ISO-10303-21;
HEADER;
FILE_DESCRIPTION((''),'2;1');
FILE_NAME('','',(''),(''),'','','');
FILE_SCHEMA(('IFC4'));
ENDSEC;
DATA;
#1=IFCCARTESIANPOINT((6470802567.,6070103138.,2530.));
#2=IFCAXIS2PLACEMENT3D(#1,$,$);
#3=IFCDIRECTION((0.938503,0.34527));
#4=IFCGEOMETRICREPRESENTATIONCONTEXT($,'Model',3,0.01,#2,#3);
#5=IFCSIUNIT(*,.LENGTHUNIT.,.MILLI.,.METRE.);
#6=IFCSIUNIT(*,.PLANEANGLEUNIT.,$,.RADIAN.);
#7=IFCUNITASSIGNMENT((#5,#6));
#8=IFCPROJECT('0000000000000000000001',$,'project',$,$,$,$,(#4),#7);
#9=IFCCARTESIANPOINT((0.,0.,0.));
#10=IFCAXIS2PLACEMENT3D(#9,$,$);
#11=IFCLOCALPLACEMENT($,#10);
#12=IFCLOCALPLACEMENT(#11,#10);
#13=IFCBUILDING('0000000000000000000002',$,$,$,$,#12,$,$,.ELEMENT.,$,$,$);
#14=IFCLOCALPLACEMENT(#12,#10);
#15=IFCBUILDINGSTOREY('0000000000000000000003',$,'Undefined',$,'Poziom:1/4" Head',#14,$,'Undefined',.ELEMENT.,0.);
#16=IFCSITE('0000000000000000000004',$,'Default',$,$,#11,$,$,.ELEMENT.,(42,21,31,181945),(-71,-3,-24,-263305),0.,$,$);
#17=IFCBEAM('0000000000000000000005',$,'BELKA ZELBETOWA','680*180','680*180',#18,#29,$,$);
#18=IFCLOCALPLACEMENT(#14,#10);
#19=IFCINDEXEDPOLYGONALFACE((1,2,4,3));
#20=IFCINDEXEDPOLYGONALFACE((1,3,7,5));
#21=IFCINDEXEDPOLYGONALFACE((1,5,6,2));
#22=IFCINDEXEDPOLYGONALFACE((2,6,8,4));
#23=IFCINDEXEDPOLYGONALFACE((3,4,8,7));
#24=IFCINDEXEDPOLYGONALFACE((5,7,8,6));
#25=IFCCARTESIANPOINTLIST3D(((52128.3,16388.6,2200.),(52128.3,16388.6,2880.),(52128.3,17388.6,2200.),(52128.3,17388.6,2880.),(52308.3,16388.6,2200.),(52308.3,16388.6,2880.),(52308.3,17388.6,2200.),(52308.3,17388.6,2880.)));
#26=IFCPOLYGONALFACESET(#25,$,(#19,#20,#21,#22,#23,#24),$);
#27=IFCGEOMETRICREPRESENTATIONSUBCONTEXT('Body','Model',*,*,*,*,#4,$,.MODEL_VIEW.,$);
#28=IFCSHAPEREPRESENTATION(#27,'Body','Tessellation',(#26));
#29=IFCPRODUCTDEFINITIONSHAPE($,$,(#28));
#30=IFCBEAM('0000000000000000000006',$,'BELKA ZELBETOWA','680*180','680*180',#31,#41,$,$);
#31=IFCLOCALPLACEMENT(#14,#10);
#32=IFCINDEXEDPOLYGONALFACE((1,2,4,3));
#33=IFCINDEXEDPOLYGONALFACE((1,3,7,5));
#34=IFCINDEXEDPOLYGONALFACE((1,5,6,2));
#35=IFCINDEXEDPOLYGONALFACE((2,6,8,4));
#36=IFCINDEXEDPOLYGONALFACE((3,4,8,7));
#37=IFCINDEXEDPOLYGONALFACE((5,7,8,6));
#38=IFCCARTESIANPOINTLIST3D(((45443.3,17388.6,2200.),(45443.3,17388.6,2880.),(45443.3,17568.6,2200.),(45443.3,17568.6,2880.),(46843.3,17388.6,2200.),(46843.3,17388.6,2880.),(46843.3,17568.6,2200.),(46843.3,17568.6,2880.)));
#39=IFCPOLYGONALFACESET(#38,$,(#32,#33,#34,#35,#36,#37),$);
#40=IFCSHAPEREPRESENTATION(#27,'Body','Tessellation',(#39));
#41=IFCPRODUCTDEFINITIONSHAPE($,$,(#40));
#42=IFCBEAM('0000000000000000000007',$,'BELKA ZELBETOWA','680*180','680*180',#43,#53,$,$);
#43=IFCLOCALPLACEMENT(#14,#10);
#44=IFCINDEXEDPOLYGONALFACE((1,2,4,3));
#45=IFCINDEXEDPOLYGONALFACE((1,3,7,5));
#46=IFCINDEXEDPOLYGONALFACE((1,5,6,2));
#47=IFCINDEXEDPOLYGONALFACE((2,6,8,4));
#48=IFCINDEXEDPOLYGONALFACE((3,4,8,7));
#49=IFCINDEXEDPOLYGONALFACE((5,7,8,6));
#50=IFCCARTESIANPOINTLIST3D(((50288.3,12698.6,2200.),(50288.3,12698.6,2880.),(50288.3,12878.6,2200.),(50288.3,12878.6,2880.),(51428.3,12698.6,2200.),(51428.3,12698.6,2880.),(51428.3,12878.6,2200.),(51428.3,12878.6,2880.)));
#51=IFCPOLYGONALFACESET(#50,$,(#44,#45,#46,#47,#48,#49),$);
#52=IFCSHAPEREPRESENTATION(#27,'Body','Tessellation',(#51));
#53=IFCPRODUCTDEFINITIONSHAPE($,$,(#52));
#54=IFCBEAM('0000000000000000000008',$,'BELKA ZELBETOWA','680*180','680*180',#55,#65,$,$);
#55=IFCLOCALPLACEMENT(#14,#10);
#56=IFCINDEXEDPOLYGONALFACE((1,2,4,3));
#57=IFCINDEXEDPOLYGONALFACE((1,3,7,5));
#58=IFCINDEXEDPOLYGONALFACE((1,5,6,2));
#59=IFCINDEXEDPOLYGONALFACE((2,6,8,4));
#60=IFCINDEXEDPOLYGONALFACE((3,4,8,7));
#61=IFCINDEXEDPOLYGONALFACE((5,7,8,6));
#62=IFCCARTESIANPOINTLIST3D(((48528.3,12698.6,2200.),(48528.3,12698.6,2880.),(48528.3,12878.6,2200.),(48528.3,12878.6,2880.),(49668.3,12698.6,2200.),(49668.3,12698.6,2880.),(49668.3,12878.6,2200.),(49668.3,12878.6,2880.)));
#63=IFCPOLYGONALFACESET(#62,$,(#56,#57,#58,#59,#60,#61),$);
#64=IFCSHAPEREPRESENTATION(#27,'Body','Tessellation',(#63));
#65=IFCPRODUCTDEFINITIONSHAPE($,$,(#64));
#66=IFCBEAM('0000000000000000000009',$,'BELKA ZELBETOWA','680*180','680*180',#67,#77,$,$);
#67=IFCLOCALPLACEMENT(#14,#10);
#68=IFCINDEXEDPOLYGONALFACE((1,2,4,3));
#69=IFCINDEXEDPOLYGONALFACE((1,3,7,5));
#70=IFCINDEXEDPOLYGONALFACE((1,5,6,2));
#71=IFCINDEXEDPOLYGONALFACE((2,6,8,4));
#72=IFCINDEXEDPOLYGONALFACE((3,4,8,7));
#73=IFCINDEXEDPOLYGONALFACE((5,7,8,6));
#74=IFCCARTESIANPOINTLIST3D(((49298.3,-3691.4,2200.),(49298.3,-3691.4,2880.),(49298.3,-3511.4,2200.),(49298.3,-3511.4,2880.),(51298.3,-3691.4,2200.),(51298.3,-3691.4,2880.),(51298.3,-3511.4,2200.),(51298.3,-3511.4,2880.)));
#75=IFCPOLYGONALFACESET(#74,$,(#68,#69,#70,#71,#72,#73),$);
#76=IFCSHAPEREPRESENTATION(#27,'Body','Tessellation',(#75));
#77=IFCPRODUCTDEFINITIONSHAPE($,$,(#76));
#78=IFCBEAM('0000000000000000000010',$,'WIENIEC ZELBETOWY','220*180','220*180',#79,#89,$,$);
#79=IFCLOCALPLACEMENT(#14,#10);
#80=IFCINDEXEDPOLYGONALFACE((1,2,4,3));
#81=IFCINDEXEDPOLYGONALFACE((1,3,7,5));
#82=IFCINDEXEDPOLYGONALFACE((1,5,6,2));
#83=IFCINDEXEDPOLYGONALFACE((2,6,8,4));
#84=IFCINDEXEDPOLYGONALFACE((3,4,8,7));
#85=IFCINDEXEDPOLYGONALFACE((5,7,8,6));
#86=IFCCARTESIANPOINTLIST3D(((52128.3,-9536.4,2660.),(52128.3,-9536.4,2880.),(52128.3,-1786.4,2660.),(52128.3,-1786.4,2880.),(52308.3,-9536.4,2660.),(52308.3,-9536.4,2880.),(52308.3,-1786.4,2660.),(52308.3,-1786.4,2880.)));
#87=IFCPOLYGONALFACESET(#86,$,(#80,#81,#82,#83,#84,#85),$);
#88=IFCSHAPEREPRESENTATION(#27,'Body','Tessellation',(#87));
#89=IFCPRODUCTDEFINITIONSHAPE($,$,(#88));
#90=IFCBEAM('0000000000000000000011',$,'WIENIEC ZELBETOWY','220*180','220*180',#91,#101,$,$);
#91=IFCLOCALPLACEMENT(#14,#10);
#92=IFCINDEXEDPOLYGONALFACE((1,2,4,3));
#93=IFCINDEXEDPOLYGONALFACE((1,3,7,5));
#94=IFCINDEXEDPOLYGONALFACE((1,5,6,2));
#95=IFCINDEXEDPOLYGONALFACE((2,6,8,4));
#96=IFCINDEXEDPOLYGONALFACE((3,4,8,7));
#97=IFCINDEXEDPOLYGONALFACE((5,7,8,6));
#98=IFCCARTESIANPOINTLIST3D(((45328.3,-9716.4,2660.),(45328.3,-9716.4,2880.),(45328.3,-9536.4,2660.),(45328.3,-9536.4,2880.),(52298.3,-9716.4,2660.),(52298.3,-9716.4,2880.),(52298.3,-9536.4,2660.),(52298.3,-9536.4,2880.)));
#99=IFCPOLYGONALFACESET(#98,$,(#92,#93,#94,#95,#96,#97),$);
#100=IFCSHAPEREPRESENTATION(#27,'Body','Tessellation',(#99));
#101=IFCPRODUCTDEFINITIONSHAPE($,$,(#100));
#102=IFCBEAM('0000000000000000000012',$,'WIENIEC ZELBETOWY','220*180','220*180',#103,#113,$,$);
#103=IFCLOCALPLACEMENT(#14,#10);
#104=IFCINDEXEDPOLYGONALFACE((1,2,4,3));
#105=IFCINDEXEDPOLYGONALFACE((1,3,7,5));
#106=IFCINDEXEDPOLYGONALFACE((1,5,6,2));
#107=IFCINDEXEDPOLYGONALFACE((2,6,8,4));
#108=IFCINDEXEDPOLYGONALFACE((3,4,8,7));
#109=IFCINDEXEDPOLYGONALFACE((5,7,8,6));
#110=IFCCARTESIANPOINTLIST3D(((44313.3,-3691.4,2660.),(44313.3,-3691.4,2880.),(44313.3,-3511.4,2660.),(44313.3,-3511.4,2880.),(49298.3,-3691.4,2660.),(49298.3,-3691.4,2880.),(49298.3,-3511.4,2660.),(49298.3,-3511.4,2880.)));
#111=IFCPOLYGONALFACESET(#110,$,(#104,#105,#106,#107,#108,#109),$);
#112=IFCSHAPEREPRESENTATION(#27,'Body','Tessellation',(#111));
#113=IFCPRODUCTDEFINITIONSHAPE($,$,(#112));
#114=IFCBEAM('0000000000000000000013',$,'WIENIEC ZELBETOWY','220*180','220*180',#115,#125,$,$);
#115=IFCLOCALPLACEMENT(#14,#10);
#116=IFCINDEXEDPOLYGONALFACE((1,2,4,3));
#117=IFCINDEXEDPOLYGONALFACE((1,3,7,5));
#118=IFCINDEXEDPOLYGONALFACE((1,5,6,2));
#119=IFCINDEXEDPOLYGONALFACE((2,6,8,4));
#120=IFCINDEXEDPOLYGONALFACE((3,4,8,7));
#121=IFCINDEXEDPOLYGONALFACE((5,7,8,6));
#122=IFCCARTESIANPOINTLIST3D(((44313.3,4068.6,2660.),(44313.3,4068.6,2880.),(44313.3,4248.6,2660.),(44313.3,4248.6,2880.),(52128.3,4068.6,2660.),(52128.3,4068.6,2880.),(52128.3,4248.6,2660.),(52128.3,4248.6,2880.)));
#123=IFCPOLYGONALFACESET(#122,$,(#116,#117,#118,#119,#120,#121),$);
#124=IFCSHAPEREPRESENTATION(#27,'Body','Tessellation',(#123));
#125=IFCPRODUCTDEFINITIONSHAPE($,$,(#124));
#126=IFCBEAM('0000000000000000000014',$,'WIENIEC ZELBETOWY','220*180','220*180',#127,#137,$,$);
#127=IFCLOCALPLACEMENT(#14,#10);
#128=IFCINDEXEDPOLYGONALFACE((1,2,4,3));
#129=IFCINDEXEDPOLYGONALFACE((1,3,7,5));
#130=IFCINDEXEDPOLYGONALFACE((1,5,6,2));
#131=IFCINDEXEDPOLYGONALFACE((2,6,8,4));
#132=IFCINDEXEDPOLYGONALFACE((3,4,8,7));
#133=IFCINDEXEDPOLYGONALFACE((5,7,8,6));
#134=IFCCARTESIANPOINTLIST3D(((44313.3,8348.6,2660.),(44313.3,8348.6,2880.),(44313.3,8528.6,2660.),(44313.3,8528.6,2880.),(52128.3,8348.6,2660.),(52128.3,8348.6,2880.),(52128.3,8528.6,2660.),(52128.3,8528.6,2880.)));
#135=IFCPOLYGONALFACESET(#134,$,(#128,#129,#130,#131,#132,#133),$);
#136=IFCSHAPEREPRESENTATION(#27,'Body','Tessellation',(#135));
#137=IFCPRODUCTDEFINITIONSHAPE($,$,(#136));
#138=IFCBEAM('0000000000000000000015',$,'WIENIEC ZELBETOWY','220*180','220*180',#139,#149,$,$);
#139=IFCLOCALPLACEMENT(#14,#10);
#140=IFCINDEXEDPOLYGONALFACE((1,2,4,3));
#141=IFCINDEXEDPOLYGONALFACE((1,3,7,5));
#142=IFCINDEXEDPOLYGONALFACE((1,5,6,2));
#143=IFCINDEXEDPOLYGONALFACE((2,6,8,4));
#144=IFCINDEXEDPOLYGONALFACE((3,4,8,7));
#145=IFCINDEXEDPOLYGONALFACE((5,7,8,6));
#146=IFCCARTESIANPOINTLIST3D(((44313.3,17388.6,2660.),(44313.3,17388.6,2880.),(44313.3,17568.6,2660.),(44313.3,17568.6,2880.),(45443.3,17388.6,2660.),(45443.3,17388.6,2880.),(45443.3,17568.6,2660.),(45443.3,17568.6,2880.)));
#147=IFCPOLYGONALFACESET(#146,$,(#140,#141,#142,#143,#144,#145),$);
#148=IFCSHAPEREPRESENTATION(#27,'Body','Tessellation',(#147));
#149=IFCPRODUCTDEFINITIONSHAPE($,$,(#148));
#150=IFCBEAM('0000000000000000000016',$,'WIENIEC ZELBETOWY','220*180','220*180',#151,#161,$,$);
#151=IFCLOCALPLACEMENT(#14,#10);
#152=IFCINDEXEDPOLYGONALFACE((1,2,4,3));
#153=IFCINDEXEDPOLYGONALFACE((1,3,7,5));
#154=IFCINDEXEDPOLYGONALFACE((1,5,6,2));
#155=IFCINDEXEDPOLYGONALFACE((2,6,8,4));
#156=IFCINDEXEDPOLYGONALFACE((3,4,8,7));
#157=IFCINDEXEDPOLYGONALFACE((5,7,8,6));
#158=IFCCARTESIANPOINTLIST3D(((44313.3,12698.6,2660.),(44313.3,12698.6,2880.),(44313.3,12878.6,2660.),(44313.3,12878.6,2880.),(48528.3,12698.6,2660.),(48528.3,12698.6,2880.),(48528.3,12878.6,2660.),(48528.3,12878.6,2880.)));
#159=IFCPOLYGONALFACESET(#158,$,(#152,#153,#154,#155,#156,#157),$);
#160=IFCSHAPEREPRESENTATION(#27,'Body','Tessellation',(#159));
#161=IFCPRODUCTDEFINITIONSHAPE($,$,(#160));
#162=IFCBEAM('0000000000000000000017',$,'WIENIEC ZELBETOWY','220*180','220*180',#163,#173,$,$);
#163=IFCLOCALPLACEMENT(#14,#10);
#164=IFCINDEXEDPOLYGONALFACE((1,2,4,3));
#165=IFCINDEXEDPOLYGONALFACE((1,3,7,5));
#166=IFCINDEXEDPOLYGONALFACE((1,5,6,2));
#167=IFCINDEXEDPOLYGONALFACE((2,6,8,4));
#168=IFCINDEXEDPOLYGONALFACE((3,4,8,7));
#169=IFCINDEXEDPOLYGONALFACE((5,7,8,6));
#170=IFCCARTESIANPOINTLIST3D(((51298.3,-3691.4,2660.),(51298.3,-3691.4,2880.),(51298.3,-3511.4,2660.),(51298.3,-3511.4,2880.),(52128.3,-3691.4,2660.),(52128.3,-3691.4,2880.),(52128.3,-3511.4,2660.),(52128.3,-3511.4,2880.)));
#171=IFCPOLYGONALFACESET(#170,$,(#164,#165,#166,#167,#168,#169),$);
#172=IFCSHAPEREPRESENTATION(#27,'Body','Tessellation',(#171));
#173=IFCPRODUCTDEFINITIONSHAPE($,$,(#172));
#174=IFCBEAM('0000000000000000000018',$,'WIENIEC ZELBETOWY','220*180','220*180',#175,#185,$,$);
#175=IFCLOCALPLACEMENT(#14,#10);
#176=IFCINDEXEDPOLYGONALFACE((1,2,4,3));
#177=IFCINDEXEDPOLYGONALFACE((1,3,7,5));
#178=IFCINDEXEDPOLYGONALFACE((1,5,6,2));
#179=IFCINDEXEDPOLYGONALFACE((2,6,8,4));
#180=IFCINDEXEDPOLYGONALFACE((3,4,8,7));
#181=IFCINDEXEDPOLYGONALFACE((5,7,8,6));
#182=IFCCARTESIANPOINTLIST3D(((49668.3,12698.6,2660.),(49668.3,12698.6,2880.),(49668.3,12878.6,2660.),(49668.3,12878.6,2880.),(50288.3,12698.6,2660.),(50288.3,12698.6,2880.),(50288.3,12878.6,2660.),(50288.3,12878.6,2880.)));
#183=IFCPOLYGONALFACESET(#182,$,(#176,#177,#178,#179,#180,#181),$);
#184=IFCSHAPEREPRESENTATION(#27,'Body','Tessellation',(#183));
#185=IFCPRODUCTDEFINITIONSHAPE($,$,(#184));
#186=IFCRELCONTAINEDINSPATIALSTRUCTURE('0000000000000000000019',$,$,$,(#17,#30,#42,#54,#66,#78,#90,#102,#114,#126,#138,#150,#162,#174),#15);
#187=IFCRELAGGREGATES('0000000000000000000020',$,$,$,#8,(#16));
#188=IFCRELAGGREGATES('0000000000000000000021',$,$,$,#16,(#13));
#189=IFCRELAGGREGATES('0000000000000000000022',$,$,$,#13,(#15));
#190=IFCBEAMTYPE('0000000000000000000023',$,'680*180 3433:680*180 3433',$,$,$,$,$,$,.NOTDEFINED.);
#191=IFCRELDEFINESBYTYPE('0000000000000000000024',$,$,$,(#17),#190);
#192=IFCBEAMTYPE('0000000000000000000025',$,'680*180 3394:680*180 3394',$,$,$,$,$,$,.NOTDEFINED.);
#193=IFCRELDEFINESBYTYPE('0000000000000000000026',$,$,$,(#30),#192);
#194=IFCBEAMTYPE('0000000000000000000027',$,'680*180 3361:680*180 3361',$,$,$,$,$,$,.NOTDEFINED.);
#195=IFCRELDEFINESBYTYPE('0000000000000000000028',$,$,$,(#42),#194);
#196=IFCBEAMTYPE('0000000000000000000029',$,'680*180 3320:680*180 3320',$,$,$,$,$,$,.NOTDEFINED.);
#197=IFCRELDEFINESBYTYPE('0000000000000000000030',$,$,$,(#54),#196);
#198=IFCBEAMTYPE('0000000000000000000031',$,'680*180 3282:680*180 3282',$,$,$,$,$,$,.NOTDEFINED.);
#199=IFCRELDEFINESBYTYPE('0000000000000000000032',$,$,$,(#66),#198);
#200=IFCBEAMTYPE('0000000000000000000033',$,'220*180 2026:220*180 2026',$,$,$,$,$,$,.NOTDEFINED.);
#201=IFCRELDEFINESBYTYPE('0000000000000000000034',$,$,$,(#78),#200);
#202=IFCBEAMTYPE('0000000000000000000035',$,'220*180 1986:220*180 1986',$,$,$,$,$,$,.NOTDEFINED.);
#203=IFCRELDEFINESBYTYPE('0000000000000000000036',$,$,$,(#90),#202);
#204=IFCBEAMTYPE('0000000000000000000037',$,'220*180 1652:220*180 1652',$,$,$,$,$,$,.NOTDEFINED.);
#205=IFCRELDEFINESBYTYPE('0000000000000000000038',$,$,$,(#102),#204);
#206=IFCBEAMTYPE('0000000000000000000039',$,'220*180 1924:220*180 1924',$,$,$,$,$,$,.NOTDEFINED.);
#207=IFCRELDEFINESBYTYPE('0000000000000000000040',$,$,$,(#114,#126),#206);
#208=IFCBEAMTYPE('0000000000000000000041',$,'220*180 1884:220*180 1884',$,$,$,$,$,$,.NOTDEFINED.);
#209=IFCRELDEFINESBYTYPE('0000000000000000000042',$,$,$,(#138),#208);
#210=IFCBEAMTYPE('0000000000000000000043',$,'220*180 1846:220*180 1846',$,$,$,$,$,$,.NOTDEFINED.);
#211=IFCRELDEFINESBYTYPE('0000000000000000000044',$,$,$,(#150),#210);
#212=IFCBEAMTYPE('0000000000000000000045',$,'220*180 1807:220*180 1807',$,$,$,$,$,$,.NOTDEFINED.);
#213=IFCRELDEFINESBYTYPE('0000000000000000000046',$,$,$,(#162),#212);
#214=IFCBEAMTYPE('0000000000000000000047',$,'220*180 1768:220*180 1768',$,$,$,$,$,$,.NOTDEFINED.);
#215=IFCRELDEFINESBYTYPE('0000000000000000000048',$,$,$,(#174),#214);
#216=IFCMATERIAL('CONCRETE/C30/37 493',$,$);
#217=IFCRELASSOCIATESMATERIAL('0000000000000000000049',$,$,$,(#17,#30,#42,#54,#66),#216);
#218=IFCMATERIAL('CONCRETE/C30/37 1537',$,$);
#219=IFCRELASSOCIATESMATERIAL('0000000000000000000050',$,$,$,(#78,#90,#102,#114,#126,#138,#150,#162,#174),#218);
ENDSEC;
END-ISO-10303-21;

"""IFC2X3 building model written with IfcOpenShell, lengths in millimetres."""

from ifc_helpers import new_model, si_unit, direction, frame, frame_2d, origin, origin_2d_with_axis, place, context, subcontext, project, spatial, rectangle, extrude, material, type_object, element, save


model = new_model("IFC2X3")

# Units and contexts
model_context = context("Model", 3, precision=0.01, world=frame((6470802567.0, 6070103138.0, 2530.0)), true_north=direction((0.938503, 0.34527)))
body_context = subcontext(model_context, "Body", "Model", "MODEL_VIEW")
ifc_project = project(units=[si_unit("LENGTHUNIT", "METRE", prefix="MILLI"), si_unit("PLANEANGLEUNIT", "RADIAN")], contexts=[model_context])

# Site, building, storey
site_placement = place(None, origin())
site = spatial("IfcSite", under=ifc_project, at=site_placement, Name="Default", CompositionType="ELEMENT", RefLatitude=(42, 21, 31, 181945), RefLongitude=(-71, -3, -24, -263305), RefElevation=0.0)
building_placement = place(site_placement, origin())
building = spatial("IfcBuilding", under=site, at=building_placement, CompositionType="ELEMENT")
storey_placement = place(building_placement, origin())
storey = spatial("IfcBuildingStorey", under=building, at=storey_placement, Name="Undefined", ObjectType="Poziom:1/4\" Head", LongName="Undefined", CompositionType="ELEMENT", Elevation=0.0)

# Beams
ifc_material_1 = material(Name="CONCRETE/C30/37 493")
beam_type_1 = type_object("IfcBeamType", Name="680*180 3433:680*180 3433", PredefinedType="NOTDEFINED")
beam_1_placement = place(storey_placement, origin())
element("IfcBeam", 1, at=beam_1_placement, inside=storey, type_object=beam_type_1, material=ifc_material_1, Name="BELKA ZELBETOWA", Description="680*180", ObjectType="680*180", context=body_context, shape_type="SweptSolid", body=[
    extrude(rectangle(XDim=680.0, YDim=1000.0, at=frame_2d((0.0, 0.0), x_axis=(0.0, 1.0))), frame((52128.3, 16888.6, 2540.0), z_axis=(1.0, 0.0, 0.0), x_axis=(0.0, -1.0, 0.0)), (0.0, 0.0, 1.0), 180.0),
])
beam_type_2 = type_object("IfcBeamType", Name="680*180 3394:680*180 3394", PredefinedType="NOTDEFINED")
beam_2_placement = place(storey_placement, origin())
element("IfcBeam", 2, at=beam_2_placement, inside=storey, type_object=beam_type_2, material=ifc_material_1, Name="BELKA ZELBETOWA", Description="680*180", ObjectType="680*180", context=body_context, shape_type="SweptSolid", body=[
    extrude(rectangle(XDim=680.0, YDim=180.0, at=frame_2d((0.0, 0.0), x_axis=(0.0, 1.0))), frame((45443.3, 17478.6, 2540.0), z_axis=(1.0, 0.0, 0.0), x_axis=(0.0, -1.0, 0.0)), (0.0, 0.0, 1.0), 1400.0),
])
beam_type_3 = type_object("IfcBeamType", Name="680*180 3361:680*180 3361", PredefinedType="NOTDEFINED")
beam_3_placement = place(storey_placement, origin())
element("IfcBeam", 3, at=beam_3_placement, inside=storey, type_object=beam_type_3, material=ifc_material_1, Name="BELKA ZELBETOWA", Description="680*180", ObjectType="680*180", context=body_context, shape_type="SweptSolid", body=[
    extrude(rectangle(XDim=680.0, YDim=180.0, at=frame_2d((0.0, 0.0), x_axis=(0.0, 1.0))), frame((50288.3, 12788.6, 2540.0), z_axis=(1.0, 0.0, 0.0), x_axis=(0.0, -1.0, 0.0)), (0.0, 0.0, 1.0), 1140.0),
])
beam_type_4 = type_object("IfcBeamType", Name="680*180 3320:680*180 3320", PredefinedType="NOTDEFINED")
beam_4_placement = place(storey_placement, origin())
element("IfcBeam", 4, at=beam_4_placement, inside=storey, type_object=beam_type_4, material=ifc_material_1, Name="BELKA ZELBETOWA", Description="680*180", ObjectType="680*180", context=body_context, shape_type="SweptSolid", body=[
    extrude(rectangle(XDim=680.0, YDim=180.0, at=frame_2d((0.0, 0.0), x_axis=(0.0, 1.0))), frame((48528.3, 12788.6, 2540.0), z_axis=(1.0, 0.0, 0.0), x_axis=(0.0, -1.0, 0.0)), (0.0, 0.0, 1.0), 1140.0),
])
beam_type_5 = type_object("IfcBeamType", Name="680*180 3282:680*180 3282", PredefinedType="NOTDEFINED")
beam_5_placement = place(storey_placement, origin())
element("IfcBeam", 5, at=beam_5_placement, inside=storey, type_object=beam_type_5, material=ifc_material_1, Name="BELKA ZELBETOWA", Description="680*180", ObjectType="680*180", context=body_context, shape_type="SweptSolid", body=[
    extrude(rectangle(XDim=680.0, YDim=180.0, at=frame_2d((0.0, 0.0), x_axis=(0.0, 1.0))), frame((49298.3, -3601.4, 2540.0), z_axis=(1.0, 0.0, 0.0), x_axis=(0.0, -1.0, 0.0)), (0.0, 0.0, 1.0), 2000.0),
])
ifc_material_2 = material(Name="CONCRETE/C30/37 1537")
beam_type_6 = type_object("IfcBeamType", Name="220*180 2026:220*180 2026", PredefinedType="NOTDEFINED")
beam_6_placement = place(storey_placement, origin())
element("IfcBeam", 6, at=beam_6_placement, inside=storey, type_object=beam_type_6, material=ifc_material_2, Name="WIENIEC ZELBETOWY", Description="220*180", ObjectType="220*180", context=body_context, shape_type="SweptSolid", body=[
    extrude(rectangle(XDim=220.0, YDim=7750.0, at=frame_2d((0.0, 0.0), x_axis=(0.0, 1.0))), frame((52128.3, -5661.4, 2770.0), z_axis=(1.0, 0.0, 0.0), x_axis=(0.0, -1.0, 0.0)), (0.0, 0.0, 1.0), 180.0),
])
beam_type_7 = type_object("IfcBeamType", Name="220*180 1986:220*180 1986", PredefinedType="NOTDEFINED")
beam_7_placement = place(storey_placement, origin())
element("IfcBeam", 7, at=beam_7_placement, inside=storey, type_object=beam_type_7, material=ifc_material_2, Name="WIENIEC ZELBETOWY", Description="220*180", ObjectType="220*180", context=body_context, shape_type="SweptSolid", body=[
    extrude(rectangle(XDim=220.0, YDim=180.0, at=origin_2d_with_axis()), frame((45328.3, -9626.4, 2770.0), z_axis=(1.0, 0.0, 0.0), x_axis=(0.0, 0.0, -1.0)), (0.0, 0.0, 1.0), 6970.0),
])
beam_type_8 = type_object("IfcBeamType", Name="220*180 1652:220*180 1652", PredefinedType="NOTDEFINED")
beam_8_placement = place(storey_placement, origin())
element("IfcBeam", 8, at=beam_8_placement, inside=storey, type_object=beam_type_8, material=ifc_material_2, Name="WIENIEC ZELBETOWY", Description="220*180", ObjectType="220*180", context=body_context, shape_type="SweptSolid", body=[
    extrude(rectangle(XDim=220.0, YDim=180.0, at=origin_2d_with_axis()), frame((44313.3, -3601.4, 2770.0), z_axis=(1.0, 0.0, 0.0), x_axis=(0.0, 0.0, -1.0)), (0.0, 0.0, 1.0), 4985.0),
])
beam_type_9 = type_object("IfcBeamType", Name="220*180 1924:220*180 1924", PredefinedType="NOTDEFINED")
beam_9_placement = place(storey_placement, origin())
element("IfcBeam", 9, at=beam_9_placement, inside=storey, type_object=beam_type_9, material=ifc_material_2, Name="WIENIEC ZELBETOWY", Description="220*180", ObjectType="220*180", context=body_context, shape_type="SweptSolid", body=[
    extrude(rectangle(XDim=220.0, YDim=180.0, at=origin_2d_with_axis()), frame((44313.3, 4158.6, 2770.0), z_axis=(1.0, 0.0, 0.0), x_axis=(0.0, 0.0, -1.0)), (0.0, 0.0, 1.0), 7815.0),
])
beam_10_placement = place(storey_placement, origin())
element("IfcBeam", 10, at=beam_10_placement, inside=storey, type_object=beam_type_9, material=ifc_material_2, Name="WIENIEC ZELBETOWY", Description="220*180", ObjectType="220*180", context=body_context, shape_type="SweptSolid", body=[
    extrude(rectangle(XDim=220.0, YDim=180.0, at=origin_2d_with_axis()), frame((44313.3, 8438.6, 2770.0), z_axis=(1.0, 0.0, 0.0), x_axis=(0.0, 0.0, -1.0)), (0.0, 0.0, 1.0), 7815.0),
])
beam_type_10 = type_object("IfcBeamType", Name="220*180 1884:220*180 1884", PredefinedType="NOTDEFINED")
beam_11_placement = place(storey_placement, origin())
element("IfcBeam", 11, at=beam_11_placement, inside=storey, type_object=beam_type_10, material=ifc_material_2, Name="WIENIEC ZELBETOWY", Description="220*180", ObjectType="220*180", context=body_context, shape_type="SweptSolid", body=[
    extrude(rectangle(XDim=220.0, YDim=180.0, at=frame_2d((0.0, 0.0), x_axis=(1.0, 0.0))), frame((44313.3, 17478.6, 2770.0), z_axis=(1.0, 0.0, 0.0), x_axis=(0.0, 0.0, -1.0)), (0.0, 0.0, 1.0), 1130.0),
])
beam_type_11 = type_object("IfcBeamType", Name="220*180 1846:220*180 1846", PredefinedType="NOTDEFINED")
beam_12_placement = place(storey_placement, origin())
element("IfcBeam", 12, at=beam_12_placement, inside=storey, type_object=beam_type_11, material=ifc_material_2, Name="WIENIEC ZELBETOWY", Description="220*180", ObjectType="220*180", context=body_context, shape_type="SweptSolid", body=[
    extrude(rectangle(XDim=220.0, YDim=180.0, at=frame_2d((0.0, 0.0), x_axis=(1.0, 0.0))), frame((44313.3, 12788.6, 2770.0), z_axis=(1.0, 0.0, 0.0), x_axis=(0.0, 0.0, -1.0)), (0.0, 0.0, 1.0), 4215.0),
])
beam_type_12 = type_object("IfcBeamType", Name="220*180 1807:220*180 1807", PredefinedType="NOTDEFINED")
beam_13_placement = place(storey_placement, origin())
element("IfcBeam", 13, at=beam_13_placement, inside=storey, type_object=beam_type_12, material=ifc_material_2, Name="WIENIEC ZELBETOWY", Description="220*180", ObjectType="220*180", context=body_context, shape_type="SweptSolid", body=[
    extrude(rectangle(XDim=220.0, YDim=180.0, at=origin_2d_with_axis()), frame((51298.3, -3601.4, 2770.0), z_axis=(1.0, 0.0, 0.0), x_axis=(0.0, 0.0, -1.0)), (0.0, 0.0, 1.0), 830.0),
])
beam_type_13 = type_object("IfcBeamType", Name="220*180 1768:220*180 1768", PredefinedType="NOTDEFINED")
beam_14_placement = place(storey_placement, origin())
element("IfcBeam", 14, at=beam_14_placement, inside=storey, type_object=beam_type_13, material=ifc_material_2, Name="WIENIEC ZELBETOWY", Description="220*180", ObjectType="220*180", context=body_context, shape_type="SweptSolid", body=[
    extrude(rectangle(XDim=220.0, YDim=180.0, at=frame_2d((0.0, 0.0), x_axis=(1.0, 0.0))), frame((49668.3, 12788.6, 2770.0), z_axis=(1.0, 0.0, 0.0), x_axis=(0.0, 0.0, -1.0)), (0.0, 0.0, 1.0), 620.0),
])

save(model, "model.ifc")
